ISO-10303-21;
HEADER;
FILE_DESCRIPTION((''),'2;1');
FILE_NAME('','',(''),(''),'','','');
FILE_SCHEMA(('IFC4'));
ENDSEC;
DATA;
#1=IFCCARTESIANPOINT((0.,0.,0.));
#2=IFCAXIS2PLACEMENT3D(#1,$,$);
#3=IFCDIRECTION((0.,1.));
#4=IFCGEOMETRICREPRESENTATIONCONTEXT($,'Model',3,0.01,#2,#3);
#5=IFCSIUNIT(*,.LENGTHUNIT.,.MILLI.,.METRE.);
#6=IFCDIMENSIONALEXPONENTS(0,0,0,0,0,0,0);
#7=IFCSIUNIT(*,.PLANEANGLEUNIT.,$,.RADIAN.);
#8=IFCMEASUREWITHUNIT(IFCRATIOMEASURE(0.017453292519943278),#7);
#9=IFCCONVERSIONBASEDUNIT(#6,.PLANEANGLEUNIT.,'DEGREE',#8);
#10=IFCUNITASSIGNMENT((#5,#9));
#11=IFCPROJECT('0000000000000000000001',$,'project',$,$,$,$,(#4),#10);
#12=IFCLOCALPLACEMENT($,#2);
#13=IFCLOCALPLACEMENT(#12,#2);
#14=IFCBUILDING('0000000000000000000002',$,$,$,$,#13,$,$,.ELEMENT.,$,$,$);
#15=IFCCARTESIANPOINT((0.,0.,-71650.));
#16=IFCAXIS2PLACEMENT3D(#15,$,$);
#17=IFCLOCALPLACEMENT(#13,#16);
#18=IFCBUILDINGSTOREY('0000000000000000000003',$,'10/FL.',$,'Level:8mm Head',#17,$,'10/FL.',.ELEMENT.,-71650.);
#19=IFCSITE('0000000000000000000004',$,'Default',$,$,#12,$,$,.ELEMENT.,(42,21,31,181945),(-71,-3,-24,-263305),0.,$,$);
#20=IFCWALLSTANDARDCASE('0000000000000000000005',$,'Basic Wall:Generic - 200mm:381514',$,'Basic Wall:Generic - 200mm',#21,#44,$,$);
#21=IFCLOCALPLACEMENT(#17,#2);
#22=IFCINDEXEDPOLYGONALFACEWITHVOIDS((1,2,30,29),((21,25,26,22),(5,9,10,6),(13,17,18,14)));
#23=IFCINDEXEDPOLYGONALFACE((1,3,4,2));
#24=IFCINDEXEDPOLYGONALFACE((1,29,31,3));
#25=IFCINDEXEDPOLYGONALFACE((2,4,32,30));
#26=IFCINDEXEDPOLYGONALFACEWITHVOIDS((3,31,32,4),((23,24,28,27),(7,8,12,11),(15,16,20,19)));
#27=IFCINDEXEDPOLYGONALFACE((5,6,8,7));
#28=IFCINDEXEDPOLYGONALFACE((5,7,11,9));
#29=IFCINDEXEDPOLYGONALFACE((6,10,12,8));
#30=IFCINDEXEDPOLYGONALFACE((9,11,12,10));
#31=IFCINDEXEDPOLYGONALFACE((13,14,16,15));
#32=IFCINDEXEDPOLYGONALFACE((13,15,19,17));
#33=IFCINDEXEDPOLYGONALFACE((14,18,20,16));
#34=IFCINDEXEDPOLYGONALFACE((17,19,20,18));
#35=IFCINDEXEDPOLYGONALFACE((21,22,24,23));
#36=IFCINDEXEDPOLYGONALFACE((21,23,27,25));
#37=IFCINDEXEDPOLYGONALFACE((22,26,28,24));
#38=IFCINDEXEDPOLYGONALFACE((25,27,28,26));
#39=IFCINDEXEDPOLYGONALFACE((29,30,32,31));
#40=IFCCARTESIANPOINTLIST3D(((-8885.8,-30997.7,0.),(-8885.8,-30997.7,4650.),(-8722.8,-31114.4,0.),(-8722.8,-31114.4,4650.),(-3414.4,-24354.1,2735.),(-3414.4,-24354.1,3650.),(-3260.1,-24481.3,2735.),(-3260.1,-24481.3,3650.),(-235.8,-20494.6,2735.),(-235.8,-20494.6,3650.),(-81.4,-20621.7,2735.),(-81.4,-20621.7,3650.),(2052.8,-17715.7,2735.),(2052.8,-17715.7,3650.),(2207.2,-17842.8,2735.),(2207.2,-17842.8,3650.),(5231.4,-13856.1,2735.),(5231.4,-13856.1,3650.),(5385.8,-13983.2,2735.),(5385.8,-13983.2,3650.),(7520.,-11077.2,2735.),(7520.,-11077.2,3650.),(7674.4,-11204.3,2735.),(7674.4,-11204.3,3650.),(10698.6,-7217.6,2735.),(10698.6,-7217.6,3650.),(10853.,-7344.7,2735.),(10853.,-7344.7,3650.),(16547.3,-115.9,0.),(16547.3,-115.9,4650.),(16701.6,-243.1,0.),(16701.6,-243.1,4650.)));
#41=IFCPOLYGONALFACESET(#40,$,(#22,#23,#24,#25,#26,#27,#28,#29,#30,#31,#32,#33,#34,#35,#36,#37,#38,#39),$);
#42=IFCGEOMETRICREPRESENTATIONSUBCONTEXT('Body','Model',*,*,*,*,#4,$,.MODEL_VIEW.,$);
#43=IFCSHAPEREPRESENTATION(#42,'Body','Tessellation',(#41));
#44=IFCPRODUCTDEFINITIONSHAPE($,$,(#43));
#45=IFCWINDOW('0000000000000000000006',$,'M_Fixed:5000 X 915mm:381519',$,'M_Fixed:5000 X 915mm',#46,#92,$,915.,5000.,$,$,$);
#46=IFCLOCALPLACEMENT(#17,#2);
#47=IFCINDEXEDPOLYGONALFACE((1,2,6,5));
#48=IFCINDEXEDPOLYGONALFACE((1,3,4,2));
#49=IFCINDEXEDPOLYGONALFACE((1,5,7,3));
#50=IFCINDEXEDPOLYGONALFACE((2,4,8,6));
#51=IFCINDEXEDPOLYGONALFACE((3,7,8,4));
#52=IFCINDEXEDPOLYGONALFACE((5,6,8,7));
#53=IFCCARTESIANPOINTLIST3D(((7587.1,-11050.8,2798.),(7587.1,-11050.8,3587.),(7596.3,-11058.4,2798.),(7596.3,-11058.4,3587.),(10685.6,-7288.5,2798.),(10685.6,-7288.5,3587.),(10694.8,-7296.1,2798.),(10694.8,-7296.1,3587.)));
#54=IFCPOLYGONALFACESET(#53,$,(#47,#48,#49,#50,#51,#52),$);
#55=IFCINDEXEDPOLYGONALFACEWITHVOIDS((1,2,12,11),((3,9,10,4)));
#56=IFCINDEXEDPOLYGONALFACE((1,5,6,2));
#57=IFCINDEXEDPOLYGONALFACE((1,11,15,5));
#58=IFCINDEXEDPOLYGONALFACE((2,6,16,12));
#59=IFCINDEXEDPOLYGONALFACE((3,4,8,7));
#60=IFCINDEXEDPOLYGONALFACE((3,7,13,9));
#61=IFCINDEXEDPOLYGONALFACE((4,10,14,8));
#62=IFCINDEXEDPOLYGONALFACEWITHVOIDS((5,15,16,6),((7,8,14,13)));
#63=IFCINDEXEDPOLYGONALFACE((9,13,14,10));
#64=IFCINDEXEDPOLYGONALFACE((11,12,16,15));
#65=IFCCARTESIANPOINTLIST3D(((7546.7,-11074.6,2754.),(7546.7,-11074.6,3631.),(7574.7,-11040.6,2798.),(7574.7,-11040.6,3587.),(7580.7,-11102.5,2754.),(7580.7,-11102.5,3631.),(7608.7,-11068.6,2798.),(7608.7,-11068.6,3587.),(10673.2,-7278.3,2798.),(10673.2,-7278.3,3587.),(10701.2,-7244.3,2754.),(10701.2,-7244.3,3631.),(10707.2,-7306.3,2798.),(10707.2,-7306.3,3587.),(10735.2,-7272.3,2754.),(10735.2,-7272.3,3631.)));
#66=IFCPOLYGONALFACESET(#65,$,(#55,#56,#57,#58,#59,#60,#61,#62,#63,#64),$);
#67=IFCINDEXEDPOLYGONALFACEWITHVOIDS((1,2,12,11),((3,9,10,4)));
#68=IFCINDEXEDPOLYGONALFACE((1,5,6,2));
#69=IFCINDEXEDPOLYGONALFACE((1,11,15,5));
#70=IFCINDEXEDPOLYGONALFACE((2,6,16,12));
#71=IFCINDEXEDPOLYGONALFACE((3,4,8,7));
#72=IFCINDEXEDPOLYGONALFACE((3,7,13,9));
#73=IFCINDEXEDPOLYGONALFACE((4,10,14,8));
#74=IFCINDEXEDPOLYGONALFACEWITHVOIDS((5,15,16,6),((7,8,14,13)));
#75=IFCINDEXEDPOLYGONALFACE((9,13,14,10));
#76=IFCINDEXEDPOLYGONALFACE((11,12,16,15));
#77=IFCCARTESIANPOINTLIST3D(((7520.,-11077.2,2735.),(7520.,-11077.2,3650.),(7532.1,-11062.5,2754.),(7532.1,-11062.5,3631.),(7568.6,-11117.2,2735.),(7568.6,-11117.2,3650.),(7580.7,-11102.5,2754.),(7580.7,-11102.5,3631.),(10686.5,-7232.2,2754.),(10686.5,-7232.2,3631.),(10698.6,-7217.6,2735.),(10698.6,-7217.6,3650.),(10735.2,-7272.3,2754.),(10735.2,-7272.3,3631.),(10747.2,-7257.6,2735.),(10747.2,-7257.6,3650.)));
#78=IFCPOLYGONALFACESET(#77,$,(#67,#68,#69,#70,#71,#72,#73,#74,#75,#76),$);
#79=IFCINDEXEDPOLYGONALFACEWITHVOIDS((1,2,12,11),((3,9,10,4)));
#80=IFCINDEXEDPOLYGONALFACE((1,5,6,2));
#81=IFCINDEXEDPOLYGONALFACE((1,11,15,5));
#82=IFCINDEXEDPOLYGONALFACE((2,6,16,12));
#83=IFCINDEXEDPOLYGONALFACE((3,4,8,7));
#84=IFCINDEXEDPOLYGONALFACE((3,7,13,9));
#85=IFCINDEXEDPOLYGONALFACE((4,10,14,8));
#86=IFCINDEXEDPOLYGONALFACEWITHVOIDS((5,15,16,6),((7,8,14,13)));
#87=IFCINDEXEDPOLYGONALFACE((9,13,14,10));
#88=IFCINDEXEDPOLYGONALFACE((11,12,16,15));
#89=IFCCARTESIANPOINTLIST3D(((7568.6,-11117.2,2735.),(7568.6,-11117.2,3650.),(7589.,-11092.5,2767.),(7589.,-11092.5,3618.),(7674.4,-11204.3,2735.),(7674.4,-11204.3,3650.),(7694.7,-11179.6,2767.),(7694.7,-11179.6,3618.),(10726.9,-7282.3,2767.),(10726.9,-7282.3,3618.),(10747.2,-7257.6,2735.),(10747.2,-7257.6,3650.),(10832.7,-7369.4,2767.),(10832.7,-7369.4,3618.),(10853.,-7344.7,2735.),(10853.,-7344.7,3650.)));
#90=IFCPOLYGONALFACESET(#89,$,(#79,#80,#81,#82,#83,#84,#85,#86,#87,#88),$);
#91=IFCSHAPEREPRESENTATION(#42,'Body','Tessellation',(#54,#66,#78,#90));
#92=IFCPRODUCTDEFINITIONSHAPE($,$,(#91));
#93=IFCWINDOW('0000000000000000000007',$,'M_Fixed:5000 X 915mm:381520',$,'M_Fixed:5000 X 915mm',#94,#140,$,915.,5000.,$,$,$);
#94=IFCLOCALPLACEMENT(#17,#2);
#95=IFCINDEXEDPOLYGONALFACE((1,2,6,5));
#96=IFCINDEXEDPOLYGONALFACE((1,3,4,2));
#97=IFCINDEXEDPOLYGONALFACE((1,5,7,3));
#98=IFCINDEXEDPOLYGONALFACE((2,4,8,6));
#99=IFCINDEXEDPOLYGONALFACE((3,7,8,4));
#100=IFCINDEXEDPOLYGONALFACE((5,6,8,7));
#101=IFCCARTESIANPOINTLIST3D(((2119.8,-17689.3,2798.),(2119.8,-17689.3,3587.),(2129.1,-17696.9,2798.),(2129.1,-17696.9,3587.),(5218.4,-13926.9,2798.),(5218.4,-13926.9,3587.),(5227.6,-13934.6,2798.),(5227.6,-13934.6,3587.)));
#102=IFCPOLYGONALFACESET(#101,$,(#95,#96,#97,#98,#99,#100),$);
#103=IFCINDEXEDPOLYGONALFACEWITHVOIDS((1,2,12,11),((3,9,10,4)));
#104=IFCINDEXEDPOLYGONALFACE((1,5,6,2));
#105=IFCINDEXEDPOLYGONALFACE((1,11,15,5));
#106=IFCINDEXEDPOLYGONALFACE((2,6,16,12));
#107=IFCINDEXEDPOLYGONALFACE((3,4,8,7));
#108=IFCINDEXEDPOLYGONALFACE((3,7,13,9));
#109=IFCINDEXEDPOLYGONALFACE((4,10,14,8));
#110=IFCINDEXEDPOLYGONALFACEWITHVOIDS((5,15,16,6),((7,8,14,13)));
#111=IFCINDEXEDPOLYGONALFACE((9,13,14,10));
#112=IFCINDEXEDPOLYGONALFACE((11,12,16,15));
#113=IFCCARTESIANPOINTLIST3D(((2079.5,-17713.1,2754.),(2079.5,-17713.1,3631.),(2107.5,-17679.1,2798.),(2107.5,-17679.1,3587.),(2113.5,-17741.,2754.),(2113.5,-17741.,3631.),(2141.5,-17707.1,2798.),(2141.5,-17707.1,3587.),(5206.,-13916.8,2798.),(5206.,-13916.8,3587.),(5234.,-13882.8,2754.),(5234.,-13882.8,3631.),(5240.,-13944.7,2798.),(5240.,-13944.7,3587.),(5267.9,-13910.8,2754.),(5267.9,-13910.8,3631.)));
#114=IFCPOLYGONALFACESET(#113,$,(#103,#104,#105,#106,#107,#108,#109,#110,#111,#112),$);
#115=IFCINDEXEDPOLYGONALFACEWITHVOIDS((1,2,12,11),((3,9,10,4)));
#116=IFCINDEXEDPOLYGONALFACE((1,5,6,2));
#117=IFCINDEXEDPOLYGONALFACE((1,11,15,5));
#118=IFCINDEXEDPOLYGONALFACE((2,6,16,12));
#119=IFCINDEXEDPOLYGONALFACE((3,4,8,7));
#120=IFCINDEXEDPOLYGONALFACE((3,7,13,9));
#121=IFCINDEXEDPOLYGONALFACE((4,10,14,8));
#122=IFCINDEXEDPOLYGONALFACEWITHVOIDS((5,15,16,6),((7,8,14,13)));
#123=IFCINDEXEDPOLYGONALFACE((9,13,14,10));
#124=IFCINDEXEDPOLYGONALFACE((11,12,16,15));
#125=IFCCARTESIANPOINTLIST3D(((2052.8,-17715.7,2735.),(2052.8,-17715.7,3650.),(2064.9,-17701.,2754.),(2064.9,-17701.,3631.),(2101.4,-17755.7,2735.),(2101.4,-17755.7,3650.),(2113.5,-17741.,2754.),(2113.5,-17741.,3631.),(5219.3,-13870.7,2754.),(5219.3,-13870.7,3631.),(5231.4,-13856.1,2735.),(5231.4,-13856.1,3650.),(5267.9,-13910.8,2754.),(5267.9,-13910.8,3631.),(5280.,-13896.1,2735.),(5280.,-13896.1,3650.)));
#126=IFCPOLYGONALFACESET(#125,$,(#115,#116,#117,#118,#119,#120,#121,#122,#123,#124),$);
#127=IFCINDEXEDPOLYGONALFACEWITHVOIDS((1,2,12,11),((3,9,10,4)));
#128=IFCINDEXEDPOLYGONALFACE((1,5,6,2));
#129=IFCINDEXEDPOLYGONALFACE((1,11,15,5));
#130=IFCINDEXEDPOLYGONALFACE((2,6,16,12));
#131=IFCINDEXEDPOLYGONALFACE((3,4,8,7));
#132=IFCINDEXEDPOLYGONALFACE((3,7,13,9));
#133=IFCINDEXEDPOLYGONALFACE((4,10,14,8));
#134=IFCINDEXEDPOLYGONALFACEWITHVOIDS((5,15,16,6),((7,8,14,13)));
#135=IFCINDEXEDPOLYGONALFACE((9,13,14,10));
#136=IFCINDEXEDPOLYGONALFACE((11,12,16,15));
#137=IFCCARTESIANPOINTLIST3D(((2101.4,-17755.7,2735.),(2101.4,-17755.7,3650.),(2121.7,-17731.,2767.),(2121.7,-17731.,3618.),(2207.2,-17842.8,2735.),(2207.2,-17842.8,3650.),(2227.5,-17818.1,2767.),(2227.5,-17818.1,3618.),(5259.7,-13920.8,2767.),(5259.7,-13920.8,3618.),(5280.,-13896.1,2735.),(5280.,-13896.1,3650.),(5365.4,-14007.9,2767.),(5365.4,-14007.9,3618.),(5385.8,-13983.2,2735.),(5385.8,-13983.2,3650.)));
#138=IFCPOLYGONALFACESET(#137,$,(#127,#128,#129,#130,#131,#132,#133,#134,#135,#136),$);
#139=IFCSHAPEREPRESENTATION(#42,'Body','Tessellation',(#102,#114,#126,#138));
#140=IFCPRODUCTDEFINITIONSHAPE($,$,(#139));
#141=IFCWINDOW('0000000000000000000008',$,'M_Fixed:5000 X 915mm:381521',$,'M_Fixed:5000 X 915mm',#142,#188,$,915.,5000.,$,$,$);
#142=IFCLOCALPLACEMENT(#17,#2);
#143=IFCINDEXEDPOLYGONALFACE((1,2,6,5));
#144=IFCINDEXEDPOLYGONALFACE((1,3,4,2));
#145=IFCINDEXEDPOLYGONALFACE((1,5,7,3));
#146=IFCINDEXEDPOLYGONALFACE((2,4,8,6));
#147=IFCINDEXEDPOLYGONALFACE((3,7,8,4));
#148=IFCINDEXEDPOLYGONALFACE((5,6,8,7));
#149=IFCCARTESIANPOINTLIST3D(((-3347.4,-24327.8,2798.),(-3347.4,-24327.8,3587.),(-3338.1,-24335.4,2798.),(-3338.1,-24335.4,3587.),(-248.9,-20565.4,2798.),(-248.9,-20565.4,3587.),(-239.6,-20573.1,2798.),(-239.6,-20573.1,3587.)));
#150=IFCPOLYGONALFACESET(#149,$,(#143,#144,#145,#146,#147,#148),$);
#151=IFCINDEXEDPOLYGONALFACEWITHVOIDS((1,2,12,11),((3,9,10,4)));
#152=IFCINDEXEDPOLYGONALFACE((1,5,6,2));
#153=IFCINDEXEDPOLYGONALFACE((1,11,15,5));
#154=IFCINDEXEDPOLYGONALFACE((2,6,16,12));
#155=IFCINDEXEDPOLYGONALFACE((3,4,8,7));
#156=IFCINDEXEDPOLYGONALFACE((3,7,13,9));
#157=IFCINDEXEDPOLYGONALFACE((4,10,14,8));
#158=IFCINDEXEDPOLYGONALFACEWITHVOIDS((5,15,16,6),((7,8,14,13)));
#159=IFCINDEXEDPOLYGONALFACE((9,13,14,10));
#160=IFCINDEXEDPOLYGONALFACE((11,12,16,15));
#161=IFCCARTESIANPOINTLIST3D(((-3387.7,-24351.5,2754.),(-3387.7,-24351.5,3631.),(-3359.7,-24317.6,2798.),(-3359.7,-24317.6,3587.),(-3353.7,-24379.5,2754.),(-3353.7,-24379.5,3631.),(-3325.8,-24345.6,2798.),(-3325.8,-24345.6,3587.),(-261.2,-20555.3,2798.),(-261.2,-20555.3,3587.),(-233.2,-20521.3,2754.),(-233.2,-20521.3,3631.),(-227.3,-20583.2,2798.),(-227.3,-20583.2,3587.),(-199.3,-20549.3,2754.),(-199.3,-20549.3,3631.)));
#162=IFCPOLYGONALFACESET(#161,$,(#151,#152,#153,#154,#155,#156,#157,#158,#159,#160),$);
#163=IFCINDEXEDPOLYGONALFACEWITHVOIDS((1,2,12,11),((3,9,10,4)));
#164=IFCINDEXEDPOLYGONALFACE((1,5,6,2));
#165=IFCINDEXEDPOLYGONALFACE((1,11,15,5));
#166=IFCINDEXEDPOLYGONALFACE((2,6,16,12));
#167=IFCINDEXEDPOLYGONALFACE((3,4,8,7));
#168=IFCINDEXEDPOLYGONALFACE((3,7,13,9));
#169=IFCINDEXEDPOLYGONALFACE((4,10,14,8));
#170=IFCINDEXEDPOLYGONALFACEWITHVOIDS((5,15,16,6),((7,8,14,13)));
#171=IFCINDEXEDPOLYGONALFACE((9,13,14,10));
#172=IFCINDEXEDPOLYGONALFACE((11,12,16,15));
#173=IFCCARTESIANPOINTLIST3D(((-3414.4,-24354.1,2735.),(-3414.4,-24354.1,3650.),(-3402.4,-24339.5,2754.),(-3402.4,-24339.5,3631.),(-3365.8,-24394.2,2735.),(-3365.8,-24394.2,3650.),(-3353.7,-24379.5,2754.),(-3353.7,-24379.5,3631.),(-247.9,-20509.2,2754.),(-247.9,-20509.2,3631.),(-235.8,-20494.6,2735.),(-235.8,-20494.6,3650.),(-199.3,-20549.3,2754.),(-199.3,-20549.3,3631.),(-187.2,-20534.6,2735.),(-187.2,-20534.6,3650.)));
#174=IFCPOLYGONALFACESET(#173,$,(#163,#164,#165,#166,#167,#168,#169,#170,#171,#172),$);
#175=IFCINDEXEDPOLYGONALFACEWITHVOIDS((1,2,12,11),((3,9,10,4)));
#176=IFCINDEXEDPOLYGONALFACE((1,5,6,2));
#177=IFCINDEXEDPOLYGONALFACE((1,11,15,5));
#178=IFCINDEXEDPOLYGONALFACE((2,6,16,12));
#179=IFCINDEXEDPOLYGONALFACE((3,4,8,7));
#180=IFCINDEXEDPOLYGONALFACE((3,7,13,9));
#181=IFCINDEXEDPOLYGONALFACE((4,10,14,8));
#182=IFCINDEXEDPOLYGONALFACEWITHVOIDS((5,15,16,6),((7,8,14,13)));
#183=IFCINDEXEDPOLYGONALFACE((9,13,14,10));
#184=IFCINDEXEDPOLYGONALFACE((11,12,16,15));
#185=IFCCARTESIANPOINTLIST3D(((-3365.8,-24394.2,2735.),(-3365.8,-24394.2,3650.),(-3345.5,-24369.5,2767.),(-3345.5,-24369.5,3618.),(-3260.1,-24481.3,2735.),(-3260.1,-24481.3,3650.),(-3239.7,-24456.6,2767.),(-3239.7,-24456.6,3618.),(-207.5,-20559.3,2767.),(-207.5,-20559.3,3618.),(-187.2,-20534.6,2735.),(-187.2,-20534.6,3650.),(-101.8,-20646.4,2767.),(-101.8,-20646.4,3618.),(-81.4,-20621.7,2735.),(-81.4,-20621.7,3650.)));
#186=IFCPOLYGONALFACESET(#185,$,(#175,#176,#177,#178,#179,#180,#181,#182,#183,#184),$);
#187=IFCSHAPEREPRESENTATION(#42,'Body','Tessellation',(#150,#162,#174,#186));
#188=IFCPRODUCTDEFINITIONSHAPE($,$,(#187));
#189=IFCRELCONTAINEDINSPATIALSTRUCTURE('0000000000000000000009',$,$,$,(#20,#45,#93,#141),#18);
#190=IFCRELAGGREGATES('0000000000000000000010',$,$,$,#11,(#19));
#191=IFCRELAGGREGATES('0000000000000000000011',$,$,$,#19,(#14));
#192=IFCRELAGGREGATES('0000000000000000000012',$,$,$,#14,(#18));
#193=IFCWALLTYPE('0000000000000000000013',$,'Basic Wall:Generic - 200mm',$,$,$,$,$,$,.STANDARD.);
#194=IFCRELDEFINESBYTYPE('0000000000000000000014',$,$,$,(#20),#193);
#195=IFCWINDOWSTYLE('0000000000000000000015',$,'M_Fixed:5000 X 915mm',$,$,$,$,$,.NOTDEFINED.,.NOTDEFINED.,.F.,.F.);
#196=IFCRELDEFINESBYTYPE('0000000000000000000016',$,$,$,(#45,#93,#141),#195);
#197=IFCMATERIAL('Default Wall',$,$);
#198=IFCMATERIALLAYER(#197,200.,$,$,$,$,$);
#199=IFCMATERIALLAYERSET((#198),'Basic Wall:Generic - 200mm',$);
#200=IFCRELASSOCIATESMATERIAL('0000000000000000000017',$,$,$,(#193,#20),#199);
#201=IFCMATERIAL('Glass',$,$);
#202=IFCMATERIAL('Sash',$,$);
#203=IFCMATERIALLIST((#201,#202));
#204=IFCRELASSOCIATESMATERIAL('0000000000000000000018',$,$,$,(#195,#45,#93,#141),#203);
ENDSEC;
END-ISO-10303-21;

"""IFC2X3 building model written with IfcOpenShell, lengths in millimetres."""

from ifc_helpers import new_model, entity, si_unit, converted_unit, direction, frame, frame_2d, origin, place, context, subcontext, project, spatial, polyline, rectangle, outline, extrude, source, transform, mapped, material, material_list, layer, layer_set, layer_usage, type_object, type_shapes, element, fill, save


model = new_model("IFC2X3")

# Units and contexts
model_context = context("Model", 3, precision=0.01, world=origin(), true_north=direction((0.0, 1.0)))
body_context = subcontext(model_context, "Body", "Model", "MODEL_VIEW")
ifc_project = project(units=[si_unit("LENGTHUNIT", "METRE", prefix="MILLI"), converted_unit("PLANEANGLEUNIT", "DEGREE", entity("IfcRatioMeasure", 0.017453292519943278), si_unit("PLANEANGLEUNIT", "RADIAN"), dimensions=[0, 0, 0, 0, 0, 0, 0])], contexts=[model_context])

# Site, building, storey
site_placement = place(None, origin())
site = spatial("IfcSite", under=ifc_project, at=site_placement, Name="Default", CompositionType="ELEMENT", RefLatitude=(42, 21, 31, 181945), RefLongitude=(-71, -3, -24, -263305), RefElevation=0.0)
building_placement = place(site_placement, origin())
building = spatial("IfcBuilding", under=site, at=building_placement, CompositionType="ELEMENT")
storey_placement = place(building_placement, frame((0.0, 0.0, -71650.0)))
storey = spatial("IfcBuildingStorey", under=building, at=storey_placement, Name="10/FL.", ObjectType="Level:8mm Head", LongName="10/FL.", CompositionType="ELEMENT", Elevation=-71650.0)

# Shared definitions
ifc_material_1 = material(Name="Default Wall")
ifc_layer = layer(ifc_material_1, 200.0)
ifc_layer_set = layer_set([ifc_layer], Name="Basic Wall:Generic - 200mm")
ifc_layer_usage = layer_usage(ifc_layer_set, "AXIS2", "NEGATIVE", 100.0)
wall_type = type_object("IfcWallType", Name="Basic Wall:Generic - 200mm", PredefinedType="STANDARD", material=ifc_layer_set)

# Wall, openings, windows
wall_1_placement = place(storey_placement, frame((17133.0, 438.0, 0.0), z_axis=(0.0, 0.0, 1.0), x_axis=(-0.635723, -0.771917, 0.0)))
wall_1 = element("IfcWallStandardCase", 1, at=wall_1_placement, inside=storey, type_object=wall_type, material=ifc_layer_usage, Name="Basic Wall:Generic - 200mm:381514", ObjectType="Basic Wall:Generic - 200mm", context=body_context, shape_type="SweptSolid", body=[
    extrude(outline(polyline([(40806.5, -100.0), (40793.0, 100.0), (37219.3, 100.0), (37019.3, 100.0), (800.0, 100.0), (800.0, -100.0), (37019.3, -100.0), (37219.3, -100.0), (40806.5, -100.0)])), origin(), (0.0, 0.0, 1.0), 4650.0),
])
opening_1_placement = place(wall_1_placement, origin())
element("IfcOpeningElement", 2, at=opening_1_placement, cuts=wall_1, ObjectType="Opening", context=body_context, shape_type="SweptSolid", body=[
    extrude(rectangle(XDim=1000.0, YDim=1012.7, at=frame_2d((0.0, 0.0), x_axis=(1.0, 0.0))), frame((293.7, -183.3, 500.0), z_axis=(0.0, 1.0, 0.0), x_axis=(0.0, 0.0, -1.0)), (0.0, 0.0, 1.0), 1010.1),
])
opening_2_placement = place(wall_1_placement, frame((15000.0, 100.0, 2735.0)))
opening_2 = element("IfcOpeningElement", 3, at=opening_2_placement, cuts=wall_1, ObjectType="Opening", context=body_context, shape_type="SweptSolid", body=[
    extrude(rectangle(XDim=915.0, YDim=5000.0, at=frame_2d((457.5, 2500.0), x_axis=(1.0, 0.0))), frame((0.0, 0.0, 0.0), z_axis=(0.0, -1.0, 0.0), x_axis=(0.0, 0.0, 1.0)), (0.0, 0.0, 1.0), 200.0),
])
opening_3_placement = place(wall_1_placement, frame((23600.0, 100.0, 2735.0)))
opening_3 = element("IfcOpeningElement", 4, at=opening_3_placement, cuts=wall_1, ObjectType="Opening", context=body_context, shape_type="SweptSolid", body=[
    extrude(rectangle(XDim=915.0, YDim=5000.0, at=frame_2d((457.5, 2500.0), x_axis=(1.0, 0.0))), frame((0.0, 0.0, 0.0), z_axis=(0.0, -1.0, 0.0), x_axis=(0.0, 0.0, 1.0)), (0.0, 0.0, 1.0), 200.0),
])
opening_4_placement = place(wall_1_placement, frame((32200.0, 100.0, 2735.0)))
opening_4 = element("IfcOpeningElement", 5, at=opening_4_placement, cuts=wall_1, ObjectType="Opening", context=body_context, shape_type="SweptSolid", body=[
    extrude(rectangle(XDim=915.0, YDim=5000.0, at=frame_2d((457.5, 2500.0), x_axis=(1.0, 0.0))), frame((0.0, 0.0, 0.0), z_axis=(0.0, -1.0, 0.0), x_axis=(0.0, 0.0, 1.0)), (0.0, 0.0, 1.0), 200.0),
])
ifc_material_2 = material(Name="Glass")
ifc_material_3 = material(Name="Sash")
ifc_material_list = material_list([ifc_material_2, ifc_material_3])
window_style_1 = type_object("IfcWindowStyle", Name="M_Fixed:5000 X 915mm", ConstructionType="NOTDEFINED", OperationType="NOTDEFINED", ParameterTakesPrecedence=False, Sizeable=False, material=ifc_material_list)
shared_shape_1 = source(origin(), body_context, "Body", "SweptSolid", [
    extrude(rectangle(XDim=12.0, YDim=4874.0, at=frame_2d((0.0, 0.0), x_axis=(1.0, 0.0))), frame((2500.0, 159.0, 63.0), z_axis=(0.0, 0.0, 1.0), x_axis=(0.0, -1.0, 0.0)), (0.0, 0.0, 1.0), 789.0),
    extrude(outline(polyline([(-2481.0, -438.5), (2481.0, -438.5), (2481.0, 438.5), (-2481.0, 438.5), (-2481.0, -438.5)]), holes=[polyline([(-2437.0, -394.5), (-2437.0, 394.5), (2437.0, 394.5), (2437.0, -394.5), (-2437.0, -394.5)])]), frame((2500.0, 137.0, 457.5), z_axis=(0.0, 1.0, 0.0), x_axis=(1.0, 0.0, 0.0)), (0.0, 0.0, 1.0), 44.0),
    extrude(outline(polyline([(-2500.0, -457.5), (2500.0, -457.5), (2500.0, 457.5), (-2500.0, 457.5), (-2500.0, -457.5)]), holes=[polyline([(-2481.0, -438.5), (-2481.0, 438.5), (2481.0, 438.5), (2481.0, -438.5), (-2481.0, -438.5)])]), frame((2500.0, 137.0, 457.5), z_axis=(0.0, 1.0, 0.0), x_axis=(1.0, 0.0, 0.0)), (0.0, 0.0, 1.0), 63.0),
    extrude(outline(polyline([(-2500.0, -457.5), (2500.0, -457.5), (2500.0, 457.5), (-2500.0, 457.5), (-2500.0, -457.5)]), holes=[polyline([(-2468.0, -425.5), (-2468.0, 425.5), (2468.0, 425.5), (2468.0, -425.5), (-2468.0, -425.5)])]), frame((2500.0, 0.0, 457.5), z_axis=(0.0, 1.0, 0.0), x_axis=(1.0, 0.0, 0.0)), (0.0, 0.0, 1.0), 137.0),
])
type_shapes(window_style_1, [shared_shape_1])
window_1_placement = place(opening_2_placement, frame((0.0, 0.0, 0.0), z_axis=(0.0, 0.0, 1.0), x_axis=(-1.0, 0.0, 0.0)))
window_1 = element("IfcWindow", 6, at=window_1_placement, inside=storey, type_object=window_style_1, material=ifc_material_list, Name="M_Fixed:5000 X 915mm:381519", ObjectType="M_Fixed:5000 X 915mm", OverallHeight=915.0, OverallWidth=5000.0, context=body_context, shape_type="MappedRepresentation", body=[
    mapped(shared_shape_1, transform((0.0, 0.0, 0.0), scale=1.0)),
])
fill(opening_2, window_1)
window_2_placement = place(opening_3_placement, frame((0.0, 0.0, 0.0), z_axis=(0.0, 0.0, 1.0), x_axis=(-1.0, 0.0, 0.0)))
window_2 = element("IfcWindow", 7, at=window_2_placement, inside=storey, type_object=window_style_1, material=ifc_material_list, Name="M_Fixed:5000 X 915mm:381520", ObjectType="M_Fixed:5000 X 915mm", OverallHeight=915.0, OverallWidth=5000.0, context=body_context, shape_type="MappedRepresentation", body=[
    mapped(shared_shape_1, transform((0.0, 0.0, 0.0), scale=1.0)),
])
fill(opening_3, window_2)
window_3_placement = place(opening_4_placement, frame((0.0, 0.0, 0.0), z_axis=(0.0, 0.0, 1.0), x_axis=(-1.0, 0.0, 0.0)))
window_3 = element("IfcWindow", 8, at=window_3_placement, inside=storey, type_object=window_style_1, material=ifc_material_list, Name="M_Fixed:5000 X 915mm:381521", ObjectType="M_Fixed:5000 X 915mm", OverallHeight=915.0, OverallWidth=5000.0, context=body_context, shape_type="MappedRepresentation", body=[
    mapped(shared_shape_1, transform((0.0, 0.0, 0.0), scale=1.0)),
])
fill(opening_4, window_3)

save(model, "model.ifc")
